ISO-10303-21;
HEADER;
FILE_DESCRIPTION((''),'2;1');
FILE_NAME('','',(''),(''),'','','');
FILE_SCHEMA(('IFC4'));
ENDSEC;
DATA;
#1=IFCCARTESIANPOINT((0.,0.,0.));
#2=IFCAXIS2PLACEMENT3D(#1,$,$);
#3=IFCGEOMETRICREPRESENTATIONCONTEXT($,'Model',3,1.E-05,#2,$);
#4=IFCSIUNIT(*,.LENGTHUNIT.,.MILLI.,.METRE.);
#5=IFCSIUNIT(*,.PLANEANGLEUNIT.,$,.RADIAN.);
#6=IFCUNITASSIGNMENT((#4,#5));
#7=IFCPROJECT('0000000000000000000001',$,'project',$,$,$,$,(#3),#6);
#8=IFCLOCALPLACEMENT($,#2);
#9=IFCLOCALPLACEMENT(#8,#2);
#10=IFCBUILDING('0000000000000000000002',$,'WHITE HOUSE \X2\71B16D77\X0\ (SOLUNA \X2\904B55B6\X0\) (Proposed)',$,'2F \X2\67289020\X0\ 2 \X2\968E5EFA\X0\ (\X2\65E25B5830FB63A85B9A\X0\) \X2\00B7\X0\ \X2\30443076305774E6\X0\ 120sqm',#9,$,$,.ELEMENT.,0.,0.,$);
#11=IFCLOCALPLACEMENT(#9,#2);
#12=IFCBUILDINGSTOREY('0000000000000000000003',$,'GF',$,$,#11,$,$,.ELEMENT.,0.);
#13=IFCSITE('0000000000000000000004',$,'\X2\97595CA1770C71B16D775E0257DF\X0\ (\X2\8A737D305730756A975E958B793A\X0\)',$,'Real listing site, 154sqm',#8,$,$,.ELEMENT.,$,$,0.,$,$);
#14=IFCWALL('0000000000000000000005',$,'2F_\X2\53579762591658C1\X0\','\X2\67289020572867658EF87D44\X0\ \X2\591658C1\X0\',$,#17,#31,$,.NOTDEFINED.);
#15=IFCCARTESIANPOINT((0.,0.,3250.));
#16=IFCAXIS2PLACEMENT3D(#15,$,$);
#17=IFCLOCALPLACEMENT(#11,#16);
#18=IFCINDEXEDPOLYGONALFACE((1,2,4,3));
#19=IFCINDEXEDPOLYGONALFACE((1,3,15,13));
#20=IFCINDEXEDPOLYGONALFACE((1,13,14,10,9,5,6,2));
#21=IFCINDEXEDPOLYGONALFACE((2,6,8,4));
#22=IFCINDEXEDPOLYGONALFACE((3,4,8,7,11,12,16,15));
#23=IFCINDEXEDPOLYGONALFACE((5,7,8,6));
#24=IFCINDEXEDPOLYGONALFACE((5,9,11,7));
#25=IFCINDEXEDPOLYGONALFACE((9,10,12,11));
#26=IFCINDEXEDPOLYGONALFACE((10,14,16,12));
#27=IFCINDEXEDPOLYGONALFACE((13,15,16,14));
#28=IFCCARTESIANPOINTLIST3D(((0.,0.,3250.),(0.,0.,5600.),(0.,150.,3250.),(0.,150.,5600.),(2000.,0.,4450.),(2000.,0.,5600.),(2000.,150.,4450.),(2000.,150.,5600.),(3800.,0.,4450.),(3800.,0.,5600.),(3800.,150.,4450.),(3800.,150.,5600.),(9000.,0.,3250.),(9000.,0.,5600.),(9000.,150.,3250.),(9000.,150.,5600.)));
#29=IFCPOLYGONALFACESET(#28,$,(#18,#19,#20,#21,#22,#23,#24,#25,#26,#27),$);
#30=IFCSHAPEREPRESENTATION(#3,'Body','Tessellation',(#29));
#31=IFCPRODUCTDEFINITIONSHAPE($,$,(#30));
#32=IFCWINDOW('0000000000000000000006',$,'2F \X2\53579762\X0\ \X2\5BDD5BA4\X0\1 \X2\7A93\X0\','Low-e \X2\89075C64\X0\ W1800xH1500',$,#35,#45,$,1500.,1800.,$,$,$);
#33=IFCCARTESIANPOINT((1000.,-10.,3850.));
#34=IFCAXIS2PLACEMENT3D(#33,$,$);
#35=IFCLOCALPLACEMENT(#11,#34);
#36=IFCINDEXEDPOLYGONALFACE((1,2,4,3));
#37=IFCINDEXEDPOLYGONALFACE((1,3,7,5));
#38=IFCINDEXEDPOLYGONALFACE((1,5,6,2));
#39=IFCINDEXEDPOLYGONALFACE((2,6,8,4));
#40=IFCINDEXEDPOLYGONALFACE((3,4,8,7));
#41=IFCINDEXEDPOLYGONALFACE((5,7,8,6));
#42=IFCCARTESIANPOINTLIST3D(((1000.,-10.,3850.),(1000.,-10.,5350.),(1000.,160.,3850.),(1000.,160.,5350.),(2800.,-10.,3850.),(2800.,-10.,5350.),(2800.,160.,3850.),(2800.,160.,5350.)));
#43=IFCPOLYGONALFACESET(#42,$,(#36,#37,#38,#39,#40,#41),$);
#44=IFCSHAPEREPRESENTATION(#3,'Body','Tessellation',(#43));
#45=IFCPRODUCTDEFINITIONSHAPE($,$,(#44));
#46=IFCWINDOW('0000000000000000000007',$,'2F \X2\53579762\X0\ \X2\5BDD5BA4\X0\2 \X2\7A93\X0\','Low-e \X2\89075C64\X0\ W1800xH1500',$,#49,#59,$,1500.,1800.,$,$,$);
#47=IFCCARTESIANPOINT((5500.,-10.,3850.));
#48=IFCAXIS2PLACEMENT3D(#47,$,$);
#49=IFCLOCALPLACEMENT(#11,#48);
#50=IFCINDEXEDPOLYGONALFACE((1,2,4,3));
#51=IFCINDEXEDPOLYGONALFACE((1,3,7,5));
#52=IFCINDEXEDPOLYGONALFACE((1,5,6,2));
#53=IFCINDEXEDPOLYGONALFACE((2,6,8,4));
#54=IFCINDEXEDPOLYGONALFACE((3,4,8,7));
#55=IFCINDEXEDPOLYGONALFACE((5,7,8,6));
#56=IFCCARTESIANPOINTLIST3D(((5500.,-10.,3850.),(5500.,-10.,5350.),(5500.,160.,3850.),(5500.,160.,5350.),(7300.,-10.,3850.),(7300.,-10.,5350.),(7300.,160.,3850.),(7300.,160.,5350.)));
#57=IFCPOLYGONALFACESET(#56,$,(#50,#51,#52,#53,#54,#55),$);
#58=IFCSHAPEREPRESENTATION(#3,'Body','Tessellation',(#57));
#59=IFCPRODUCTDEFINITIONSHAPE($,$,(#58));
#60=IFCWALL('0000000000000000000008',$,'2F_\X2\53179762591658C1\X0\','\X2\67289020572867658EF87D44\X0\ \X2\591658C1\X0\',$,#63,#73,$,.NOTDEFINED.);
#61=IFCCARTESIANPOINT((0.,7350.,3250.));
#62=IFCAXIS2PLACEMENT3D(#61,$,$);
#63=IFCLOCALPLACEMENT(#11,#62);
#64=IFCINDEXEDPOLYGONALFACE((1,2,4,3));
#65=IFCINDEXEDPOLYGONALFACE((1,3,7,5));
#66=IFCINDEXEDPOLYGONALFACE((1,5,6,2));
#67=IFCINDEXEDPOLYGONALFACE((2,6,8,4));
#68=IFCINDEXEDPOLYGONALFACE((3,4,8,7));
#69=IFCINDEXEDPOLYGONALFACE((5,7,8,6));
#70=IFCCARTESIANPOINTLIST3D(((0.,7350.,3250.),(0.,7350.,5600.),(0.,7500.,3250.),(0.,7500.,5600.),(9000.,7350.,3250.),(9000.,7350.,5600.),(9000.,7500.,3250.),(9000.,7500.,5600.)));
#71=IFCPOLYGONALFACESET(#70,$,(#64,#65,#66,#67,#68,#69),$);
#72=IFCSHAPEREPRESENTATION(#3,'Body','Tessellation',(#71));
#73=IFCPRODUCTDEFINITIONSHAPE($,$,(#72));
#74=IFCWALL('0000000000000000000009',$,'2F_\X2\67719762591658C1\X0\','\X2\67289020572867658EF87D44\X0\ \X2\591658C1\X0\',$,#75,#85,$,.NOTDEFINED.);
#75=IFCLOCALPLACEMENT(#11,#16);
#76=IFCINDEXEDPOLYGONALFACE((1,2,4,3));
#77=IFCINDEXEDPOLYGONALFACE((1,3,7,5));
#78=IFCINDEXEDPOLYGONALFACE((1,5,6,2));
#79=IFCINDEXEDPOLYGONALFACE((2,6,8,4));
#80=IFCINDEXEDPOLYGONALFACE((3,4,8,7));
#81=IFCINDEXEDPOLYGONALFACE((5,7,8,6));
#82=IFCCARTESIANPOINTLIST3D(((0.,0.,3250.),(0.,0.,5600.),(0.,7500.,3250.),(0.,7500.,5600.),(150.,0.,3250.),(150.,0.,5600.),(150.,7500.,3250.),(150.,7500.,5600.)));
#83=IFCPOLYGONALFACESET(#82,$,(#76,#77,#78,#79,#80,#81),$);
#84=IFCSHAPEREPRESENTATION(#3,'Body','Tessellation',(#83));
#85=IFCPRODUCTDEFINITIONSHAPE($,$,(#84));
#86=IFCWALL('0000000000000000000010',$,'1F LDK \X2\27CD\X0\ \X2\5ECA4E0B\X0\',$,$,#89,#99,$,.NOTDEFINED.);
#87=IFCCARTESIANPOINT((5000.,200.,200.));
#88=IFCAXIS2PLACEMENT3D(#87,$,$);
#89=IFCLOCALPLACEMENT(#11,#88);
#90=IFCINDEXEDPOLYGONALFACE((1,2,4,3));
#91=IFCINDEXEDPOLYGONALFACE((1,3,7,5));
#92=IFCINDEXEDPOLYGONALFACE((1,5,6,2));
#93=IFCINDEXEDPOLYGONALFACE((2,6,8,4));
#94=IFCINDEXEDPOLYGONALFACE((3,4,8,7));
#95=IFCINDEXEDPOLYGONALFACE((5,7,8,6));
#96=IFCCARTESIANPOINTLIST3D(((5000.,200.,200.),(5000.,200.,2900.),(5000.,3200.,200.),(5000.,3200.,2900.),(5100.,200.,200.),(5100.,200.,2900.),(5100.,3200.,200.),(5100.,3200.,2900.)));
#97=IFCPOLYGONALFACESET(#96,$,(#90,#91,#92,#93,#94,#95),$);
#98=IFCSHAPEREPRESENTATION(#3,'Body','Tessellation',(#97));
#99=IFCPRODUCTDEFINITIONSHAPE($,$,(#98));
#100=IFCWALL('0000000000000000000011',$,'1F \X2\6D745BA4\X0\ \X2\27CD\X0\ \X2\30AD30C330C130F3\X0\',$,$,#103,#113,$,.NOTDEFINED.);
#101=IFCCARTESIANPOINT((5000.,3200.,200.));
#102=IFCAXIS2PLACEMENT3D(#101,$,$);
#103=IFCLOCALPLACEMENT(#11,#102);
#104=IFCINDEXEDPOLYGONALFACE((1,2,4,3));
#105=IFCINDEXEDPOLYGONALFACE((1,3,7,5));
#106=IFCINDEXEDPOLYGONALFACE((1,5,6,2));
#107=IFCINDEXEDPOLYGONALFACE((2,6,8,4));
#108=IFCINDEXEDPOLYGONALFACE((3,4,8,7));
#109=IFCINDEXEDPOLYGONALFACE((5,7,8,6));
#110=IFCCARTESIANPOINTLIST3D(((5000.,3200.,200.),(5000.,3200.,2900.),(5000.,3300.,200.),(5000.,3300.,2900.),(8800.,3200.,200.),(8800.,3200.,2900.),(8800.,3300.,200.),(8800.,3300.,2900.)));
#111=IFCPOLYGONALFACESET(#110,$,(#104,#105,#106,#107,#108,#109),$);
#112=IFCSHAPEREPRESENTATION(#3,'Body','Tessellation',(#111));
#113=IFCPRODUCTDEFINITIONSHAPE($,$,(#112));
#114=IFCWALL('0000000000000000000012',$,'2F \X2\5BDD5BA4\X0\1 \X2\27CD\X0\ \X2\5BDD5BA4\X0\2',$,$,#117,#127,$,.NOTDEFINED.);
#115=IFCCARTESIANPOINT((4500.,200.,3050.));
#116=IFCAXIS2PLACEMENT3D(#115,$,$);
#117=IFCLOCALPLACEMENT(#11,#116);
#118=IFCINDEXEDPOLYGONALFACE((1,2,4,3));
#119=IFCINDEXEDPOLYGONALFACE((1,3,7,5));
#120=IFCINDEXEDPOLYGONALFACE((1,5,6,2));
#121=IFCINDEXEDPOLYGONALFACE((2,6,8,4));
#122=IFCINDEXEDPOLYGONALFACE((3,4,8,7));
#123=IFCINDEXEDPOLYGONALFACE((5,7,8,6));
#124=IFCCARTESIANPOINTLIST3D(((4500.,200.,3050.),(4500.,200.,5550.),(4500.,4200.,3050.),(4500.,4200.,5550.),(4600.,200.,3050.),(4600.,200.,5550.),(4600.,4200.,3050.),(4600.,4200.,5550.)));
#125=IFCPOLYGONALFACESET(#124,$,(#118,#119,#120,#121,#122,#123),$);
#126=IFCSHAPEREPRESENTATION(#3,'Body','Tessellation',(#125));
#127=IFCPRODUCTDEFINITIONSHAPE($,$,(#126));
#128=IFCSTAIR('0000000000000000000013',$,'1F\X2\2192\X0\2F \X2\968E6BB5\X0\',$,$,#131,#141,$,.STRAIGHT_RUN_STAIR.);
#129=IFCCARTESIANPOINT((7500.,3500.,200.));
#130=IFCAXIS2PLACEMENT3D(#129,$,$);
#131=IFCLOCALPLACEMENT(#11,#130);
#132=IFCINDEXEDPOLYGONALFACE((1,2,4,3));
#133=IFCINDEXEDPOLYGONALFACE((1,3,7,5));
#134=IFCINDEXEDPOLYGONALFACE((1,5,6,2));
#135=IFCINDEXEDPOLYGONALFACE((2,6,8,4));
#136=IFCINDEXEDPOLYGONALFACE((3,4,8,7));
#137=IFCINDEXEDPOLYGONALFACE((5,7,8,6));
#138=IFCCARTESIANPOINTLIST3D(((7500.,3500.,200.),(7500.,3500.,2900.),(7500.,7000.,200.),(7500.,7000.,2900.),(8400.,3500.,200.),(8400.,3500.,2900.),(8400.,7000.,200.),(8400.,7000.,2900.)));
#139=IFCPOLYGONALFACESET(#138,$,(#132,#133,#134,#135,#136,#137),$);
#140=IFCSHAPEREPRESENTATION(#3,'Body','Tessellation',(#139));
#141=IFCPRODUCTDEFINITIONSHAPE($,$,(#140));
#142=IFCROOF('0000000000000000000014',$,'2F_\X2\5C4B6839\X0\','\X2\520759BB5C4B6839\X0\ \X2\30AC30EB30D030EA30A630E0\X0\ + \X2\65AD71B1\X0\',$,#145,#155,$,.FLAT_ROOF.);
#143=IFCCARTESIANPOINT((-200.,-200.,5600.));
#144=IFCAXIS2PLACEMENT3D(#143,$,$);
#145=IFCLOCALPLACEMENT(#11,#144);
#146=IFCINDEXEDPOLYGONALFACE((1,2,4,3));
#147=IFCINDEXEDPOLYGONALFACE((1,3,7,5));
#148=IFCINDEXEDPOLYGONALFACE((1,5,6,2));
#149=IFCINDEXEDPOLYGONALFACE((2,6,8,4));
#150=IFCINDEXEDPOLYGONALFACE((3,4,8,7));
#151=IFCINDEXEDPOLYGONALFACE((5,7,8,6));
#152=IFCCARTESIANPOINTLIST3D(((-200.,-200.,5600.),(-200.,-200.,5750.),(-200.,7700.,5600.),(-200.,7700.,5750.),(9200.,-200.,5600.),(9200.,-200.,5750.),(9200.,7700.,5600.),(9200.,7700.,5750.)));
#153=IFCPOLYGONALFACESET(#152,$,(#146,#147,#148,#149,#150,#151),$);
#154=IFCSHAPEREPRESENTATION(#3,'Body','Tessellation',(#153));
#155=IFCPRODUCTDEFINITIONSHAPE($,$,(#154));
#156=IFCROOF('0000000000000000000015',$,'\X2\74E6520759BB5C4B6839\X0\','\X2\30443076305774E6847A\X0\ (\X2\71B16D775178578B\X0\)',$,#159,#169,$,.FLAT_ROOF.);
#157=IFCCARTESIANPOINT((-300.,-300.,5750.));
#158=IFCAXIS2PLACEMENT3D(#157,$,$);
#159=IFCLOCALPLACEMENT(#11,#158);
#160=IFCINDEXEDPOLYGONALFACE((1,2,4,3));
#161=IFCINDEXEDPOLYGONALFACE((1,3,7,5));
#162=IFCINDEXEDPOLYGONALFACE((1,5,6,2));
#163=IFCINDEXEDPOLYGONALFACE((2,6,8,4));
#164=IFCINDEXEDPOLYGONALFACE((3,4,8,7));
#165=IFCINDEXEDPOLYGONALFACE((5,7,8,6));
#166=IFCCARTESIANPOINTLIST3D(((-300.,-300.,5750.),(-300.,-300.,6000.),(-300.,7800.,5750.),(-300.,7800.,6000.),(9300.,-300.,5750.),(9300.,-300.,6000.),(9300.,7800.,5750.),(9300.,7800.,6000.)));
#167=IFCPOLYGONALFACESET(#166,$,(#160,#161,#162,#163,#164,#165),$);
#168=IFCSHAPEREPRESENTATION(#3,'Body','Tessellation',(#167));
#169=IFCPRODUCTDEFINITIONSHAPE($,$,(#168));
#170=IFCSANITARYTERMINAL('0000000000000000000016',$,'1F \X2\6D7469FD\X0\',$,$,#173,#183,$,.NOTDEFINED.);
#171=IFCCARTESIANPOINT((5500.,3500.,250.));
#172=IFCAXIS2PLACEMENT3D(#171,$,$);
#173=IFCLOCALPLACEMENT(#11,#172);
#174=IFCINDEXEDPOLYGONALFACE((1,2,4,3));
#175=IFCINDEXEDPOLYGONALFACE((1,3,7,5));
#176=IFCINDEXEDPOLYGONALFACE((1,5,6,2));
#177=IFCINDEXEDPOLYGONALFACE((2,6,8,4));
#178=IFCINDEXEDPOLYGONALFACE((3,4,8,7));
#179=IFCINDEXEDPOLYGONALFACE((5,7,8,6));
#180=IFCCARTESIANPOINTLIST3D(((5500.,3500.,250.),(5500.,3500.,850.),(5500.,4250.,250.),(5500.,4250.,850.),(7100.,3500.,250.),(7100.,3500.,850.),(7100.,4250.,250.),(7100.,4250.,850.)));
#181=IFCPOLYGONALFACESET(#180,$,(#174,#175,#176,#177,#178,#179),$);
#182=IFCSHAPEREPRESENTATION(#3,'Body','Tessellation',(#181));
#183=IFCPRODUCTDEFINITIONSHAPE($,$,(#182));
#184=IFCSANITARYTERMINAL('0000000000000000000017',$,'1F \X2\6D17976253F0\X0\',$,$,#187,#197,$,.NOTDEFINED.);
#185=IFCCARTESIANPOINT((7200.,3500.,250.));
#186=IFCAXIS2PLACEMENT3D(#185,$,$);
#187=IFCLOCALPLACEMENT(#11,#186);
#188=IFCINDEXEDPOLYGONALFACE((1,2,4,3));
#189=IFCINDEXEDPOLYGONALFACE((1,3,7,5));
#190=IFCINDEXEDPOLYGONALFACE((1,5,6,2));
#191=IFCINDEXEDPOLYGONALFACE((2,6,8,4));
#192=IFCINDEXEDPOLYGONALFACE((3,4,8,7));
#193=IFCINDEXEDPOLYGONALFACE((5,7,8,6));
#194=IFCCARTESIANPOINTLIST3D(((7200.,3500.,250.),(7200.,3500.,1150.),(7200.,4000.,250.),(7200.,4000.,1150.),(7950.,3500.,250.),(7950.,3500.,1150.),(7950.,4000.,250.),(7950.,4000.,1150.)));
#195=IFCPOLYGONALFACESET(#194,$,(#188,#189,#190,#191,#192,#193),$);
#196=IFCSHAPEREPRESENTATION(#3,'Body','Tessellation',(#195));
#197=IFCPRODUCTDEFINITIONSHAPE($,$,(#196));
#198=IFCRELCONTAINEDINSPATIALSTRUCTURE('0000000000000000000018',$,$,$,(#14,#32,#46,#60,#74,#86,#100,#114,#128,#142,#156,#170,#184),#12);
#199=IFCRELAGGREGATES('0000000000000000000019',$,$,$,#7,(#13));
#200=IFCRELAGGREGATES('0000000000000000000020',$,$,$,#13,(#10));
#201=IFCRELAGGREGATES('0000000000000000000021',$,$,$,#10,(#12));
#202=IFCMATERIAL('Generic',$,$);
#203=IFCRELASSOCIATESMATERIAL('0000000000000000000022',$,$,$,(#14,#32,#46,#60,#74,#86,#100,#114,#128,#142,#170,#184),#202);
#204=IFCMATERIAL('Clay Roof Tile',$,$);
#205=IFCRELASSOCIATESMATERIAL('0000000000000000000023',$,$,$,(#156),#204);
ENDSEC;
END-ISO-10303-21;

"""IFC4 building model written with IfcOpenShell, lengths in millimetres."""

from ifc_helpers import new_model, si_unit, frame, frame_2d, origin, place, context, project, spatial, rectangle, extrude, material, element, fill, save


model = new_model("IFC4")

# Units and contexts
model_context = context("Model", 3, precision=1e-05, world=origin())
ifc_project = project(units=[si_unit("LENGTHUNIT", "METRE", prefix="MILLI"), si_unit("PLANEANGLEUNIT", "RADIAN")], contexts=[model_context])

# Site, building, storey
site_placement = place(None, origin())
site = spatial("IfcSite", under=ifc_project, at=site_placement, Name="静岡県熱海市域 (詳細地番非開示)", ObjectType="Real listing site, 154sqm", CompositionType="ELEMENT", RefElevation=0.0)
building_placement = place(site_placement, origin())
building = spatial("IfcBuilding", under=site, at=building_placement, Name="WHITE HOUSE 熱海 (SOLUNA 運営) (Proposed)", ObjectType="2F 木造 2 階建 (既存・推定) · いぶし瓦 120sqm", CompositionType="ELEMENT", ElevationOfRefHeight=0.0, ElevationOfTerrain=0.0)
storey_placement = place(building_placement, origin())
storey = spatial("IfcBuildingStorey", under=building, at=storey_placement, Name="GF", CompositionType="ELEMENT", Elevation=0.0)

# Shared definitions
ifc_material_1 = material(Name="Generic")

# Wall, openings, windows
wall_1_placement = place(storey_placement, frame((0.0, 0.0, 3250.0)))
wall_1 = element("IfcWall", 1, at=wall_1_placement, inside=storey, material=ifc_material_1, Name="2F_南面外壁", Description="木造在来軸組 外壁", PredefinedType="NOTDEFINED", context=model_context, shape_type="SweptSolid", body=[
    extrude(rectangle(XDim=9000.0, YDim=150.0, at=frame_2d((4500.0, 75.0))), frame((0.0, 0.0, 3250.0)), (0.0, 0.0, 1.0), 2350.0),
])
opening_1_placement = place(storey_placement, frame((1000.0, -10.0, 3850.0)))
opening_1 = element("IfcOpeningElement", 2, at=opening_1_placement, cuts=wall_1, PredefinedType="NOTDEFINED", context=model_context, shape_type="SweptSolid", body=[
    extrude(rectangle(XDim=1800.0, YDim=170.0, at=frame_2d((900.0, 85.0))), frame((1000.0, -10.0, 3850.0)), (0.0, 0.0, 1.0), 1500.0),
])
opening_2_placement = place(storey_placement, frame((5500.0, -10.0, 3850.0)))
opening_2 = element("IfcOpeningElement", 3, at=opening_2_placement, cuts=wall_1, PredefinedType="NOTDEFINED", context=model_context, shape_type="SweptSolid", body=[
    extrude(rectangle(XDim=1800.0, YDim=170.0, at=frame_2d((900.0, 85.0))), frame((5500.0, -10.0, 3850.0)), (0.0, 0.0, 1.0), 1500.0),
])
window_1_placement = place(storey_placement, frame((1000.0, -10.0, 3850.0)))
window_1 = element("IfcWindow", 4, at=window_1_placement, inside=storey, material=ifc_material_1, Name="2F 南面 寝室1 窓", Description="Low-e 複層 W1800xH1500", OverallHeight=1500.0, OverallWidth=1800.0, context=model_context, shape_type="SweptSolid", body=[
    extrude(rectangle(XDim=1800.0, YDim=170.0, at=frame_2d((900.0, 85.0))), frame((1000.0, -10.0, 3850.0)), (0.0, 0.0, 1.0), 1500.0),
])
fill(opening_1, window_1)
window_2_placement = place(storey_placement, frame((5500.0, -10.0, 3850.0)))
window_2 = element("IfcWindow", 5, at=window_2_placement, inside=storey, material=ifc_material_1, Name="2F 南面 寝室2 窓", Description="Low-e 複層 W1800xH1500", OverallHeight=1500.0, OverallWidth=1800.0, context=model_context, shape_type="SweptSolid", body=[
    extrude(rectangle(XDim=1800.0, YDim=170.0, at=frame_2d((900.0, 85.0))), frame((5500.0, -10.0, 3850.0)), (0.0, 0.0, 1.0), 1500.0),
])
fill(opening_2, window_2)

# Walls
wall_2_placement = place(storey_placement, frame((0.0, 7350.0, 3250.0)))
element("IfcWall", 6, at=wall_2_placement, inside=storey, material=ifc_material_1, Name="2F_北面外壁", Description="木造在来軸組 外壁", PredefinedType="NOTDEFINED", context=model_context, shape_type="SweptSolid", body=[
    extrude(rectangle(XDim=9000.0, YDim=150.0, at=frame_2d((4500.0, 75.0))), frame((0.0, 7350.0, 3250.0)), (0.0, 0.0, 1.0), 2350.0),
])
wall_3_placement = place(storey_placement, frame((0.0, 0.0, 3250.0)))
element("IfcWall", 7, at=wall_3_placement, inside=storey, material=ifc_material_1, Name="2F_東面外壁", Description="木造在来軸組 外壁", PredefinedType="NOTDEFINED", context=model_context, shape_type="SweptSolid", body=[
    extrude(rectangle(XDim=150.0, YDim=7500.0, at=frame_2d((75.0, 3750.0))), frame((0.0, 0.0, 3250.0)), (0.0, 0.0, 1.0), 2350.0),
])
wall_4_placement = place(storey_placement, frame((5000.0, 200.0, 200.0)))
element("IfcWall", 8, at=wall_4_placement, inside=storey, material=ifc_material_1, Name="1F LDK ⟍ 廊下", PredefinedType="NOTDEFINED", context=model_context, shape_type="SweptSolid", body=[
    extrude(rectangle(XDim=100.0, YDim=3000.0, at=frame_2d((50.0, 1500.0))), frame((5000.0, 200.0, 200.0)), (0.0, 0.0, 1.0), 2700.0),
])
wall_5_placement = place(storey_placement, frame((5000.0, 3200.0, 200.0)))
element("IfcWall", 9, at=wall_5_placement, inside=storey, material=ifc_material_1, Name="1F 浴室 ⟍ キッチン", PredefinedType="NOTDEFINED", context=model_context, shape_type="SweptSolid", body=[
    extrude(rectangle(XDim=3800.0, YDim=100.0, at=frame_2d((1900.0, 50.0))), frame((5000.0, 3200.0, 200.0)), (0.0, 0.0, 1.0), 2700.0),
])
wall_6_placement = place(storey_placement, frame((4500.0, 200.0, 3050.0)))
element("IfcWall", 10, at=wall_6_placement, inside=storey, material=ifc_material_1, Name="2F 寝室1 ⟍ 寝室2", PredefinedType="NOTDEFINED", context=model_context, shape_type="SweptSolid", body=[
    extrude(rectangle(XDim=100.0, YDim=4000.0, at=frame_2d((50.0, 2000.0))), frame((4500.0, 200.0, 3050.0)), (0.0, 0.0, 1.0), 2500.0),
])

# Stair
stair_placement = place(storey_placement, frame((7500.0, 3500.0, 200.0)))
element("IfcStair", 11, at=stair_placement, inside=storey, material=ifc_material_1, Name="1F→2F 階段", PredefinedType="STRAIGHT_RUN_STAIR", context=model_context, shape_type="SweptSolid", body=[
    extrude(rectangle(XDim=900.0, YDim=3500.0, at=frame_2d((450.0, 1750.0))), frame((7500.0, 3500.0, 200.0)), (0.0, 0.0, 1.0), 2700.0),
])

# Roofs
roof_1_placement = place(storey_placement, frame((-200.0, -200.0, 5600.0)))
element("IfcRoof", 12, at=roof_1_placement, inside=storey, material=ifc_material_1, Name="2F_屋根", Description="切妻屋根 ガルバリウム + 断熱", PredefinedType="FLAT_ROOF", context=model_context, shape_type="SweptSolid", body=[
    extrude(rectangle(XDim=9400.0, YDim=7900.0, at=frame_2d((4700.0, 3950.0))), frame((-200.0, -200.0, 5600.0)), (0.0, 0.0, 1.0), 150.0),
])
ifc_material_2 = material(Name="Clay Roof Tile")
roof_2_placement = place(storey_placement, frame((-300.0, -300.0, 5750.0)))
element("IfcRoof", 13, at=roof_2_placement, inside=storey, material=ifc_material_2, Name="瓦切妻屋根", Description="いぶし瓦葺 (熱海典型)", PredefinedType="FLAT_ROOF", context=model_context, shape_type="SweptSolid", body=[
    extrude(rectangle(XDim=9600.0, YDim=8100.0, at=frame_2d((4800.0, 4050.0))), frame((-300.0, -300.0, 5750.0)), (0.0, 0.0, 1.0), 250.0),
])

# Sanitary terminals
sanitary_terminal_1_placement = place(storey_placement, frame((5500.0, 3500.0, 250.0)))
element("IfcSanitaryTerminal", 14, at=sanitary_terminal_1_placement, inside=storey, material=ifc_material_1, Name="1F 浴槽", PredefinedType="NOTDEFINED", context=model_context, shape_type="SweptSolid", body=[
    extrude(rectangle(XDim=1600.0, YDim=750.0, at=frame_2d((800.0, 375.0))), frame((5500.0, 3500.0, 250.0)), (0.0, 0.0, 1.0), 600.0),
])
sanitary_terminal_2_placement = place(storey_placement, frame((7200.0, 3500.0, 250.0)))
element("IfcSanitaryTerminal", 15, at=sanitary_terminal_2_placement, inside=storey, material=ifc_material_1, Name="1F 洗面台", PredefinedType="NOTDEFINED", context=model_context, shape_type="SweptSolid", body=[
    extrude(rectangle(XDim=750.0, YDim=500.0, at=frame_2d((375.0, 250.0))), frame((7200.0, 3500.0, 250.0)), (0.0, 0.0, 1.0), 900.0),
])

save(model, "model.ifc")
